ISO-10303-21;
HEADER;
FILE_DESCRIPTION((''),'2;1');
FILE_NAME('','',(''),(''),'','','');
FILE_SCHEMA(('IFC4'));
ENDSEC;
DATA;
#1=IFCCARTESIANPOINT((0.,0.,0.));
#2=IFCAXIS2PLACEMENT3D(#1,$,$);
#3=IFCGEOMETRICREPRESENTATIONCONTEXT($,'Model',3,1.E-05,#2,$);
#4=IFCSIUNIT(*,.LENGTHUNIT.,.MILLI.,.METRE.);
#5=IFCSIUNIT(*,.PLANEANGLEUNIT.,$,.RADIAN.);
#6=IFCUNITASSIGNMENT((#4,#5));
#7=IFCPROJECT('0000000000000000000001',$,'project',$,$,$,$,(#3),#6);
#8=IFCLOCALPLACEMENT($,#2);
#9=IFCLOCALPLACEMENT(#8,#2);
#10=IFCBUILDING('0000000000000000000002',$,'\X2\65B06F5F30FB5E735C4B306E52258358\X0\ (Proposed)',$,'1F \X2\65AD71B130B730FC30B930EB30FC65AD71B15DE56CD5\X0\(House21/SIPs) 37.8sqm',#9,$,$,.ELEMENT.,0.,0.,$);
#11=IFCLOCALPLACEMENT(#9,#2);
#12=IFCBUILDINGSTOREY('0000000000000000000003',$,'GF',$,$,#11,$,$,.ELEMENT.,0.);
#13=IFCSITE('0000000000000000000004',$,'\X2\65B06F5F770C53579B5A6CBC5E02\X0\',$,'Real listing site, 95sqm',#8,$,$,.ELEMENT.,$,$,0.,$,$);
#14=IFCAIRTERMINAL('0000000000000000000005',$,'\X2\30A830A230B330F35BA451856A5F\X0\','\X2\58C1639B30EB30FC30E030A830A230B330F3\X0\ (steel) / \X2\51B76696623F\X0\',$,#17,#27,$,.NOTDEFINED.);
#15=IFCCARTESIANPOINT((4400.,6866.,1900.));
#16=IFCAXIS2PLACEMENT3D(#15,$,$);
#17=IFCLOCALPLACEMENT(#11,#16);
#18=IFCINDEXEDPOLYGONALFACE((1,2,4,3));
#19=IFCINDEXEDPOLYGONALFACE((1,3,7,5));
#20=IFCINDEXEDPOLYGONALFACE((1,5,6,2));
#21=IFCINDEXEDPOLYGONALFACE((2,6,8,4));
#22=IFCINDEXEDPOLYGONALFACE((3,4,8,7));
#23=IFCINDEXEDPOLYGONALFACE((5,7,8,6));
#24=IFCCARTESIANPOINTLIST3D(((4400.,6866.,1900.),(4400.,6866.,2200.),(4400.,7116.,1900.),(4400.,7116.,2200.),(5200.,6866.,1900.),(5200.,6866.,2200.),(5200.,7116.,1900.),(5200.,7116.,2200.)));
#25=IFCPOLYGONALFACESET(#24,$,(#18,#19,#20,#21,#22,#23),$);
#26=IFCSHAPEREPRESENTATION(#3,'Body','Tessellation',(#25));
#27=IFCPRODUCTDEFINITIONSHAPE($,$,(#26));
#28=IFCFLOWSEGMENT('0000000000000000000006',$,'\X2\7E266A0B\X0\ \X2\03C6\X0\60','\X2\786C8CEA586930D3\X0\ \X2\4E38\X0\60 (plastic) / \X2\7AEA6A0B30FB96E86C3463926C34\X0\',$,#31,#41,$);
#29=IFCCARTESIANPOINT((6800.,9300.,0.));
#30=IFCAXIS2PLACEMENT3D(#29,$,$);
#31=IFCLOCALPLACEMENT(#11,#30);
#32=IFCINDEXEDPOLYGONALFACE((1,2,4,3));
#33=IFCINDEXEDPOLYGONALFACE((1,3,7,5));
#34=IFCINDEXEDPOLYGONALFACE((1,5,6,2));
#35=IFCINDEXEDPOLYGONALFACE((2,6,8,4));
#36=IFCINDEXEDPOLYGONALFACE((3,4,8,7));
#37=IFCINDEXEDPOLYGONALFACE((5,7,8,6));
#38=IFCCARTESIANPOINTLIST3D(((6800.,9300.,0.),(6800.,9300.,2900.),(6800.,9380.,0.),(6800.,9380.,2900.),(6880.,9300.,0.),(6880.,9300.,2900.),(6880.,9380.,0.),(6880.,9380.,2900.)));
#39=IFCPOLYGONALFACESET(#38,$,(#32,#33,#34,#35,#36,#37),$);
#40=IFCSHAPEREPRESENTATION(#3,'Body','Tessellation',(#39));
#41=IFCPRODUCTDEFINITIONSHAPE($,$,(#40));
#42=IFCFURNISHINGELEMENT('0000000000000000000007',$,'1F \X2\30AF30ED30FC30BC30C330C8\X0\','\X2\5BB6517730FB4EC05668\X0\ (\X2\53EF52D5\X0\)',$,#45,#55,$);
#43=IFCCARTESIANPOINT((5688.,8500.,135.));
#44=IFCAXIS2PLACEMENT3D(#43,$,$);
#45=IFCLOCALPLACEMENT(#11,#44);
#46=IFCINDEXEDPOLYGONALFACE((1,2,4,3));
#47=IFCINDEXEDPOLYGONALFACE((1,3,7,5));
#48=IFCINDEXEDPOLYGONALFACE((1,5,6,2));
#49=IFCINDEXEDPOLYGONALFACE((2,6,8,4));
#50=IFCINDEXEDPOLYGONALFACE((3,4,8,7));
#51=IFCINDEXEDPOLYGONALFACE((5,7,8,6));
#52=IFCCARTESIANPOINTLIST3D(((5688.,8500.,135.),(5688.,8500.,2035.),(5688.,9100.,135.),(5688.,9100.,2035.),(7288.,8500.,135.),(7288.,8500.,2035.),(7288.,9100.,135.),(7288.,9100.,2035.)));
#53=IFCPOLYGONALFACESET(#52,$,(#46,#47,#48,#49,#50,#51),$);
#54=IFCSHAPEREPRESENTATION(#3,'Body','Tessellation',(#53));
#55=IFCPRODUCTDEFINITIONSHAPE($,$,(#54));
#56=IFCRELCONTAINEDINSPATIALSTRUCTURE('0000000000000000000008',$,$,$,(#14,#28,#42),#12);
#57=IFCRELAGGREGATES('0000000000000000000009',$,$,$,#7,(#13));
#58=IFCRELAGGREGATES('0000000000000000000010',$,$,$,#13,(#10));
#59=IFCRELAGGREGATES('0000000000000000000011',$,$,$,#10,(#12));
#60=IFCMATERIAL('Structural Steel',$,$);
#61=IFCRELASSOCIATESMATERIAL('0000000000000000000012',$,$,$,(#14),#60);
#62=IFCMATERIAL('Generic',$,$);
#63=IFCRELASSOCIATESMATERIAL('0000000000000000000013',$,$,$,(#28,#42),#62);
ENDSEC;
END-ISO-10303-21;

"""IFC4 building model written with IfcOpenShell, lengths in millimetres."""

from ifc_helpers import new_model, si_unit, frame, frame_2d, origin, place, context, project, spatial, rectangle, extrude, material, element, save


model = new_model("IFC4")

# Units and contexts
model_context = context("Model", 3, precision=1e-05, world=origin())
ifc_project = project(units=[si_unit("LENGTHUNIT", "METRE", prefix="MILLI"), si_unit("PLANEANGLEUNIT", "RADIAN")], contexts=[model_context])

# Site, building, storey
site_placement = place(None, origin())
site = spatial("IfcSite", under=ifc_project, at=site_placement, Name="新潟県南魚沼市", ObjectType="Real listing site, 95sqm", CompositionType="ELEMENT", RefElevation=0.0)
building_placement = place(site_placement, origin())
building = spatial("IfcBuilding", under=site, at=building_placement, Name="新潟・平屋の別荘 (Proposed)", ObjectType="1F 断熱シースルー断熱工法(House21/SIPs) 37.8sqm", CompositionType="ELEMENT", ElevationOfRefHeight=0.0, ElevationOfTerrain=0.0)
storey_placement = place(building_placement, origin())
storey = spatial("IfcBuildingStorey", under=building, at=storey_placement, Name="GF", CompositionType="ELEMENT", Elevation=0.0)

# Shared definitions
ifc_material_1 = material(Name="Structural Steel")

# Shared definitions
ifc_material_2 = material(Name="Generic")

# Air terminal
air_terminal_placement = place(storey_placement, frame((4400.0, 6866.0, 1900.0)))
element("IfcAirTerminal", 1, at=air_terminal_placement, inside=storey, material=ifc_material_1, Name="エアコン室内機", Description="壁掛ルームエアコン (steel) / 冷暖房", PredefinedType="NOTDEFINED", context=model_context, shape_type="SweptSolid", body=[
    extrude(rectangle(XDim=800.0, YDim=250.0, at=frame_2d((400.0, 125.0))), frame((4400.0, 6866.0, 1900.0)), (0.0, 0.0, 1.0), 300.0),
])

# Flow segment
flow_segment_placement = place(storey_placement, frame((6800.0, 9300.0, 0.0)))
element("IfcFlowSegment", 2, at=flow_segment_placement, inside=storey, material=ifc_material_2, Name="縦樋 φ60", Description="硬質塩ビ 丸60 (plastic) / 竪樋・雨水排水", context=model_context, shape_type="SweptSolid", body=[
    extrude(rectangle(XDim=80.0, YDim=80.0, at=frame_2d((40.0, 40.0))), frame((6800.0, 9300.0, 0.0)), (0.0, 0.0, 1.0), 2900.0),
])

# Furnishing element
furnishing_placement = place(storey_placement, frame((5688.0, 8500.0, 135.0)))
element("IfcFurnishingElement", 3, at=furnishing_placement, inside=storey, material=ifc_material_2, Name="1F クローゼット", Description="家具・什器 (可動)", context=model_context, shape_type="SweptSolid", body=[
    extrude(rectangle(XDim=1600.0, YDim=600.0, at=frame_2d((800.0, 300.0))), frame((5688.0, 8500.0, 135.0)), (0.0, 0.0, 1.0), 1900.0),
])

save(model, "model.ifc")
